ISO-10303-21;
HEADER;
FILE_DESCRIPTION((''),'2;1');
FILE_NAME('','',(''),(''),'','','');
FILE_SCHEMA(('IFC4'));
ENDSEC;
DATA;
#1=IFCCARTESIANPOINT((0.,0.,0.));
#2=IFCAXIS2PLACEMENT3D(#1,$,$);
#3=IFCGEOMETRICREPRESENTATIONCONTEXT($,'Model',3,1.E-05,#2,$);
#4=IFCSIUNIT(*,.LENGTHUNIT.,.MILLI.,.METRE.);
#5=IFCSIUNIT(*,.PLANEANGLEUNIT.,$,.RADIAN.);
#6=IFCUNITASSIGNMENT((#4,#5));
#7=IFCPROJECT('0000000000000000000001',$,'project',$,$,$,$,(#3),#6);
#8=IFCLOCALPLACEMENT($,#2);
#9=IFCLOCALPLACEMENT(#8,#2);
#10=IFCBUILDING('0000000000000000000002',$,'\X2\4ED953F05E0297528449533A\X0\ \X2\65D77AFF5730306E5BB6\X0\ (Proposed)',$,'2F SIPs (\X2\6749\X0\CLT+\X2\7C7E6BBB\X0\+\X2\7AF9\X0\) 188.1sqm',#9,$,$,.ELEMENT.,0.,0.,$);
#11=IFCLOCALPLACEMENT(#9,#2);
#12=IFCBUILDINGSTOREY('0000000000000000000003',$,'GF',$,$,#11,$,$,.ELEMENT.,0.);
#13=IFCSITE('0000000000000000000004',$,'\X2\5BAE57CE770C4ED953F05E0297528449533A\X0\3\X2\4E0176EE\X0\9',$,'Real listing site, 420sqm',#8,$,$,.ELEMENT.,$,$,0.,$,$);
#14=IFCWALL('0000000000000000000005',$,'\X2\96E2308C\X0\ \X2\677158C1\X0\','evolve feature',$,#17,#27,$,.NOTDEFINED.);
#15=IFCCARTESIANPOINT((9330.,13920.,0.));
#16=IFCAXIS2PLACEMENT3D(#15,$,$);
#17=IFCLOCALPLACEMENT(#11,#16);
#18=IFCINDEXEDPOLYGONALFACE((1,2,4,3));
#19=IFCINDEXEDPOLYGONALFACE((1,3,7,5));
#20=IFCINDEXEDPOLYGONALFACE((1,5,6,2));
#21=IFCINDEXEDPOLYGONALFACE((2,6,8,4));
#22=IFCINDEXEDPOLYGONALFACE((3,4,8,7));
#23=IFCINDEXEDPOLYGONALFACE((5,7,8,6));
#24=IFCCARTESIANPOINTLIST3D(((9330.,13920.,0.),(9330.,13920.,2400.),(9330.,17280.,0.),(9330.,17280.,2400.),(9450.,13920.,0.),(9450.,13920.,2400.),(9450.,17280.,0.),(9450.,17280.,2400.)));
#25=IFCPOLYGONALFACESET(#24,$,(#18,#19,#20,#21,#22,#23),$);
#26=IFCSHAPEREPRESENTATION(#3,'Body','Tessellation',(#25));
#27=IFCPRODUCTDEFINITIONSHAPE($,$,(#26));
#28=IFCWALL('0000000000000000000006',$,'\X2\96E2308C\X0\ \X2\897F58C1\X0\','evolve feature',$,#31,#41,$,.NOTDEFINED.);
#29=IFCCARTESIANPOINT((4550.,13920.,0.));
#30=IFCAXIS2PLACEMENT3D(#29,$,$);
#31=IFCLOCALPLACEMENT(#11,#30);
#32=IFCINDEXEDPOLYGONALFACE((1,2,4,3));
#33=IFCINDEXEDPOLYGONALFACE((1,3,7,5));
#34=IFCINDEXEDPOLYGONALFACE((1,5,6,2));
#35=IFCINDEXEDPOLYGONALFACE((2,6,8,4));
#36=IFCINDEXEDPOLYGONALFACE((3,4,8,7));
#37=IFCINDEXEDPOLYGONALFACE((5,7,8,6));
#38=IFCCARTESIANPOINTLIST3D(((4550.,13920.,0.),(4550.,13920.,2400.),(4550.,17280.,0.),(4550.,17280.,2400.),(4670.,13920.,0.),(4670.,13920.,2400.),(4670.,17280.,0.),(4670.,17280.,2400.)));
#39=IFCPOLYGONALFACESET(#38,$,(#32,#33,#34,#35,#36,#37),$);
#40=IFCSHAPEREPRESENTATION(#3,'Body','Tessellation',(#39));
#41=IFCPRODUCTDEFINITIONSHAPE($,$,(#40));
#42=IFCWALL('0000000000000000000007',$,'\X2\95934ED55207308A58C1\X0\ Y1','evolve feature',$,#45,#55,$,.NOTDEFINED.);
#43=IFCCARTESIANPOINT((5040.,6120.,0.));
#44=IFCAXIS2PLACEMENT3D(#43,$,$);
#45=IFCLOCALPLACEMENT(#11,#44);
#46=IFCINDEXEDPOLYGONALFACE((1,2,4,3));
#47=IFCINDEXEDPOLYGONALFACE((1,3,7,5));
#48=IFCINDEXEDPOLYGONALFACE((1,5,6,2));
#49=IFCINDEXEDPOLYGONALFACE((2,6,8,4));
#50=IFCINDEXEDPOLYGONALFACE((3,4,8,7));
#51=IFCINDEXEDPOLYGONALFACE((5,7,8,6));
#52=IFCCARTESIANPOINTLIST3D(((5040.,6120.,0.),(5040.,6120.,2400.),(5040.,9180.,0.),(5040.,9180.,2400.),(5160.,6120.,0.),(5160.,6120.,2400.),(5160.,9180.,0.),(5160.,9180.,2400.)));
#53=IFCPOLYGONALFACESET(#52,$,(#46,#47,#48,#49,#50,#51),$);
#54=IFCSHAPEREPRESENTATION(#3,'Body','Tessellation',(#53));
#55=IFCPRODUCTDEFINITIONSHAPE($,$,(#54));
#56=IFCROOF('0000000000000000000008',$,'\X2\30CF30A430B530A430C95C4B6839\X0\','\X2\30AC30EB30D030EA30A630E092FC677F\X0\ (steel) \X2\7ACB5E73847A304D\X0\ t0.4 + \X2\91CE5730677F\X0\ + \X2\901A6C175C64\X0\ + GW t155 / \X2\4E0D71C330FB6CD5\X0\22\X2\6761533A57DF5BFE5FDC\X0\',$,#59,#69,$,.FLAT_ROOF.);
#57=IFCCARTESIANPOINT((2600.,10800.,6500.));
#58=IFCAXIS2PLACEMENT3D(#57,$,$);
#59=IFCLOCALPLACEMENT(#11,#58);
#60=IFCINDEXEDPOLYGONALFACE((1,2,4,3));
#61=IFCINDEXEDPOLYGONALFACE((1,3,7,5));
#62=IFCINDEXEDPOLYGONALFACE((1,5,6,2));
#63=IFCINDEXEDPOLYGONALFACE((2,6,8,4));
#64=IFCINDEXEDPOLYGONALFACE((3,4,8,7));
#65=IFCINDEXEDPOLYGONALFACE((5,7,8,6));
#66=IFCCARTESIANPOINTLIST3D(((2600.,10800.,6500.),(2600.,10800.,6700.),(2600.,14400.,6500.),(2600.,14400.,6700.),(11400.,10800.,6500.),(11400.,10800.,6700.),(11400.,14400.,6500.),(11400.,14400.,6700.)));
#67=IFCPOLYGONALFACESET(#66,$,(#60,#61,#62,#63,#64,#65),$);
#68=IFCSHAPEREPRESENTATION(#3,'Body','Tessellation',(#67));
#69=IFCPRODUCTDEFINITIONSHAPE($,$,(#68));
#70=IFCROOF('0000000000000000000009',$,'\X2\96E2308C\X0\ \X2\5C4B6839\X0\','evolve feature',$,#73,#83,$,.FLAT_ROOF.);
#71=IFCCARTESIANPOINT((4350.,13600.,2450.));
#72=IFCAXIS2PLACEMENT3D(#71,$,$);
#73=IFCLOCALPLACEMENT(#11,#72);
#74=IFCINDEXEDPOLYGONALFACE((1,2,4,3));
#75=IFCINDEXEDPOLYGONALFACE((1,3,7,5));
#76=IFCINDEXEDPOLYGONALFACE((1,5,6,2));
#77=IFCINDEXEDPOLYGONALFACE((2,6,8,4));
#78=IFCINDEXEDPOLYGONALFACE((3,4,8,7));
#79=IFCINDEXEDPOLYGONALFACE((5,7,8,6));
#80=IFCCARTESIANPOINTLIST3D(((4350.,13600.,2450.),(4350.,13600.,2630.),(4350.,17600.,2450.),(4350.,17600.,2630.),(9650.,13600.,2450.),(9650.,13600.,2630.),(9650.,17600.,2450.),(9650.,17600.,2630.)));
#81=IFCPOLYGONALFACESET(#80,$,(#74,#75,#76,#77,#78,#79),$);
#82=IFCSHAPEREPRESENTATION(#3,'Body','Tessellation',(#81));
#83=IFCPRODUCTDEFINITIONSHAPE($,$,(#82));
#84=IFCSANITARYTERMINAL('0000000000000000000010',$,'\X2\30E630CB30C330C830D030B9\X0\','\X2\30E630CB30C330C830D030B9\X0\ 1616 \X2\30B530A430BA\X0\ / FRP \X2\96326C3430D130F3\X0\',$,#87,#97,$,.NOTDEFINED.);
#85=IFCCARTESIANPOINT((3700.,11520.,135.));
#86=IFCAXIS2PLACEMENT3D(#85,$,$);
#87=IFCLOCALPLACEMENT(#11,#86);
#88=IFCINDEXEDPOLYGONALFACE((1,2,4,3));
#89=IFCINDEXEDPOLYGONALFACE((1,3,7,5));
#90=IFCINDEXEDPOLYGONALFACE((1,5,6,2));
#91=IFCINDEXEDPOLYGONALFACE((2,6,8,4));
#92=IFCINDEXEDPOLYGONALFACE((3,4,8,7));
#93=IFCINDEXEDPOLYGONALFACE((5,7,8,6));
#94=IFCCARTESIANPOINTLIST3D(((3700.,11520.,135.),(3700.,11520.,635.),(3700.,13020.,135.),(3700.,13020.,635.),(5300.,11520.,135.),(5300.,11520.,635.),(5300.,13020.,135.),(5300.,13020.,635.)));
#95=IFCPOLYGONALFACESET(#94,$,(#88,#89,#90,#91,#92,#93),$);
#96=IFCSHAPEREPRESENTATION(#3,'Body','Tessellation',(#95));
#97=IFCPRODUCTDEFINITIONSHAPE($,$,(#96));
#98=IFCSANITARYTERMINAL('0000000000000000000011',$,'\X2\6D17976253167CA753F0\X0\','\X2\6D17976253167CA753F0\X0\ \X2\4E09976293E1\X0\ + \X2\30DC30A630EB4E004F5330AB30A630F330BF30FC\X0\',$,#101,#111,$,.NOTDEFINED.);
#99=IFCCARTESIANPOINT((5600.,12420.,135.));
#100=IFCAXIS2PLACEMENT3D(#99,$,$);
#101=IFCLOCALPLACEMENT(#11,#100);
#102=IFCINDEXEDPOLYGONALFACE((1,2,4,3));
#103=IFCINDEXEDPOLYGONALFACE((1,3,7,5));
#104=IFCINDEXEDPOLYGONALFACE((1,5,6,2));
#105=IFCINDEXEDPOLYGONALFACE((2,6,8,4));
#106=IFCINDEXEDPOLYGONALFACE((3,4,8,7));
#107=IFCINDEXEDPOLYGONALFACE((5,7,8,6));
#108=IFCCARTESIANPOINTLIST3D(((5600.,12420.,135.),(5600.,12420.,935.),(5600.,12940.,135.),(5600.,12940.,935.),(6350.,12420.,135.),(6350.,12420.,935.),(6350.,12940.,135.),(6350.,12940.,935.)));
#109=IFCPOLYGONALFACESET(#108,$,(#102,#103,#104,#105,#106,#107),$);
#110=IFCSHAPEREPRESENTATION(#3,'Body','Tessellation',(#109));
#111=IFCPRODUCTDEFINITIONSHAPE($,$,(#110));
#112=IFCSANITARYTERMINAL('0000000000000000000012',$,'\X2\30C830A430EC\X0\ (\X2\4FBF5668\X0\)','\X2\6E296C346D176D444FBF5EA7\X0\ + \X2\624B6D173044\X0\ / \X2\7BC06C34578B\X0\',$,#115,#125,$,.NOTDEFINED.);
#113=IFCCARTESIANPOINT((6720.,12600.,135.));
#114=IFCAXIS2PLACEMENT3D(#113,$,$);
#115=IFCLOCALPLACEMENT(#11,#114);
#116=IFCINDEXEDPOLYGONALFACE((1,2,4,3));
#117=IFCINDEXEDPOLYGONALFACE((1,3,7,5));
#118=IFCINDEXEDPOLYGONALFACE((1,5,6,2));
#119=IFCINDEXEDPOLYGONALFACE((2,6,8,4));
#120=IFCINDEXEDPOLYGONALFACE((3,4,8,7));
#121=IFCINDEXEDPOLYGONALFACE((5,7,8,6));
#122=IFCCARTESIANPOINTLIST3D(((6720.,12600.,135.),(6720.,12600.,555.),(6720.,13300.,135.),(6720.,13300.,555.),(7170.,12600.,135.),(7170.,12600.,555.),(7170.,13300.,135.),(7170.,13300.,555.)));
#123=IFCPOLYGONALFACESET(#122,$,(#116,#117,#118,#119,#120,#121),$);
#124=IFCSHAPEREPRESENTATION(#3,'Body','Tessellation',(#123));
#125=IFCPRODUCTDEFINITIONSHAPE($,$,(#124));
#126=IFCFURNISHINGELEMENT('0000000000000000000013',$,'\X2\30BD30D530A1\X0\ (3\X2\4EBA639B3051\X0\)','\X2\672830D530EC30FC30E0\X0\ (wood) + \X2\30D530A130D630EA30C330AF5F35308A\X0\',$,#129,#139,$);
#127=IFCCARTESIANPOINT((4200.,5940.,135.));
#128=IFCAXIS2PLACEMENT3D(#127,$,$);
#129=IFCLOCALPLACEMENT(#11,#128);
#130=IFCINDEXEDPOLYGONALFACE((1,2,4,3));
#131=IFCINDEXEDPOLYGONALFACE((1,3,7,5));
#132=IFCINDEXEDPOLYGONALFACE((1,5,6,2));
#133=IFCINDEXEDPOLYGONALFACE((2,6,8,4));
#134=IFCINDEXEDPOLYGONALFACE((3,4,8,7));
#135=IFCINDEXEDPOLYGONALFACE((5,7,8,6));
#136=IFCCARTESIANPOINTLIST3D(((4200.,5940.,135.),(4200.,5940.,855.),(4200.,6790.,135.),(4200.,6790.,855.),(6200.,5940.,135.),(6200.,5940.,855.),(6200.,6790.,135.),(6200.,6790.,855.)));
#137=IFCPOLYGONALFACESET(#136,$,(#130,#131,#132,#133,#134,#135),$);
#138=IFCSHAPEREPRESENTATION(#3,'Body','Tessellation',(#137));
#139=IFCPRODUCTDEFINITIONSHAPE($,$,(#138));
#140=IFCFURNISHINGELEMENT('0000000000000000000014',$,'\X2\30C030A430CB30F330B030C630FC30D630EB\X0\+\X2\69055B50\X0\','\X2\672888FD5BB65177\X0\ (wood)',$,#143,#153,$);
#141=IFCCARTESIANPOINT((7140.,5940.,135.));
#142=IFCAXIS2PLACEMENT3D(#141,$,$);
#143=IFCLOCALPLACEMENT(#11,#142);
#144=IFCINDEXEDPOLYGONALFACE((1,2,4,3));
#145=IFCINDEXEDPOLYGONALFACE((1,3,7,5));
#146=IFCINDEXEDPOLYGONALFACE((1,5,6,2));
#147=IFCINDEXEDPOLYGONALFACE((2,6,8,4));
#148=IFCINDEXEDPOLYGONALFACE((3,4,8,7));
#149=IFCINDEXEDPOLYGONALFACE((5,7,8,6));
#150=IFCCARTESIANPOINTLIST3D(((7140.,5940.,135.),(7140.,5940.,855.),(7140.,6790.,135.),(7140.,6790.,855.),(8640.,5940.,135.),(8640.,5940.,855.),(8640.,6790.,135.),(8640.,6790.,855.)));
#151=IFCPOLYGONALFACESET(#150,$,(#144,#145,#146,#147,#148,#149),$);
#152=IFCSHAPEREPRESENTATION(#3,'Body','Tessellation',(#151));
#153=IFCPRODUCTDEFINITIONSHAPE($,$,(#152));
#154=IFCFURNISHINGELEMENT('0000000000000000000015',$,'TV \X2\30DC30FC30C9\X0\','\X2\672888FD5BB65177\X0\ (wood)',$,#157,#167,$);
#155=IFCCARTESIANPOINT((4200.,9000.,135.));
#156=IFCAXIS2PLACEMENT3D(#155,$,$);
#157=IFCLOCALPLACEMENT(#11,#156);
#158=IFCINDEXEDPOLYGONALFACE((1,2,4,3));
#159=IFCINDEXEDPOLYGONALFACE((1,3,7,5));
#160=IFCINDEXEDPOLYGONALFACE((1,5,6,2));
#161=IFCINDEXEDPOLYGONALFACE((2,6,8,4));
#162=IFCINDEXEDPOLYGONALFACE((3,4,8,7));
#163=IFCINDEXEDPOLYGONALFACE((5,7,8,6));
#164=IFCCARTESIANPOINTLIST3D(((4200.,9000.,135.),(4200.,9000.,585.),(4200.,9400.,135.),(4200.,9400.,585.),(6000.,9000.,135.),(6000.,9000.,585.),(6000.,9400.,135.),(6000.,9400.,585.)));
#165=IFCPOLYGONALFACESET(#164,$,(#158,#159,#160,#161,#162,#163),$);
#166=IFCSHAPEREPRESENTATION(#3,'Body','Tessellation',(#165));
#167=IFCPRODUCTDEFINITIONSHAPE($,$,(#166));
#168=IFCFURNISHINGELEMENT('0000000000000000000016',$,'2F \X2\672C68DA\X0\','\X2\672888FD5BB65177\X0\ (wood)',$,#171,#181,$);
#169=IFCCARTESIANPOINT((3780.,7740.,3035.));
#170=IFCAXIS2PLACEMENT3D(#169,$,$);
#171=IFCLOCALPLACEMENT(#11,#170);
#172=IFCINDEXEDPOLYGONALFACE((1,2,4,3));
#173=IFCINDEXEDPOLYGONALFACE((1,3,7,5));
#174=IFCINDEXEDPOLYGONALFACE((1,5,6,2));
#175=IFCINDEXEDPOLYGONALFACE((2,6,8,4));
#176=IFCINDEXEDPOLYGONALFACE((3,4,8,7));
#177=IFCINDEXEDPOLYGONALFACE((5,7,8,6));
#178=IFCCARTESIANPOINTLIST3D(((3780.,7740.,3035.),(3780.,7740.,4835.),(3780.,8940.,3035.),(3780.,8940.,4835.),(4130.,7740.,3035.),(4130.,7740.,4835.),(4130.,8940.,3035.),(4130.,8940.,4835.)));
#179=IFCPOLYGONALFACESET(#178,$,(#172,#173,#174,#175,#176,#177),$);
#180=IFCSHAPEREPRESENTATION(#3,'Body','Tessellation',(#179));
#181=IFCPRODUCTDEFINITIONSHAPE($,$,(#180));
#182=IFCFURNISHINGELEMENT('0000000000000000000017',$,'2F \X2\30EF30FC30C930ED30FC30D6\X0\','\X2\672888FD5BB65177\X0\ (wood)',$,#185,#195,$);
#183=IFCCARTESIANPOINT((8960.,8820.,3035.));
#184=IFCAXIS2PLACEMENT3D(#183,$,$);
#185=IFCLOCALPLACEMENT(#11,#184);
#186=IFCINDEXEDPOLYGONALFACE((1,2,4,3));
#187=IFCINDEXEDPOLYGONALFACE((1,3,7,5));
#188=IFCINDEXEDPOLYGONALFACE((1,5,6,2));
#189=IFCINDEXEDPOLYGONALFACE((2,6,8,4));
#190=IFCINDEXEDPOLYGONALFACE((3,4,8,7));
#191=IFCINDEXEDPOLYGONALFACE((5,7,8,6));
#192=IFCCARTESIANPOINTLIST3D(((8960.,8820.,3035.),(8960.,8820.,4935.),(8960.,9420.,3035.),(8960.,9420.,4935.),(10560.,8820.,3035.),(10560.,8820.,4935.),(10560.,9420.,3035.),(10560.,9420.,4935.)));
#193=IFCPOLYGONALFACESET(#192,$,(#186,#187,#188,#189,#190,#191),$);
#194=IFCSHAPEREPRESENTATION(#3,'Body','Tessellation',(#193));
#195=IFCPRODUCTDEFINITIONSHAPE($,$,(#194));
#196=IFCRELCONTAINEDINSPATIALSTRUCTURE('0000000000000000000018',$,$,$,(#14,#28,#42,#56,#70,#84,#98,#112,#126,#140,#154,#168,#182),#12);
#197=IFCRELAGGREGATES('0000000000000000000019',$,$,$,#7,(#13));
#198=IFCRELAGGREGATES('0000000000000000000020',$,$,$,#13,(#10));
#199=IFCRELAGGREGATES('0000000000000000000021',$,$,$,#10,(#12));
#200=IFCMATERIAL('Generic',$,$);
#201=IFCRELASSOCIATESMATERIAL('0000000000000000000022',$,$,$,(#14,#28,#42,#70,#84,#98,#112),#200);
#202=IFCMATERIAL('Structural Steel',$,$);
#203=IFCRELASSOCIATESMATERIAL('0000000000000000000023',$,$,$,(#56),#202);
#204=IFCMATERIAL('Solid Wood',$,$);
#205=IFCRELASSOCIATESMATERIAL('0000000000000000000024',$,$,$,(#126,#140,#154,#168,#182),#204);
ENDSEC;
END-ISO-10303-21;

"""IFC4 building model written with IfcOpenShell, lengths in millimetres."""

from ifc_helpers import new_model, si_unit, frame, frame_2d, origin, place, context, project, spatial, rectangle, extrude, material, element, save


model = new_model("IFC4")

# Units and contexts
model_context = context("Model", 3, precision=1e-05, world=origin())
ifc_project = project(units=[si_unit("LENGTHUNIT", "METRE", prefix="MILLI"), si_unit("PLANEANGLEUNIT", "RADIAN")], contexts=[model_context])

# Site, building, storey
site_placement = place(None, origin())
site = spatial("IfcSite", under=ifc_project, at=site_placement, Name="宮城県仙台市青葉区3丁目9", ObjectType="Real listing site, 420sqm", CompositionType="ELEMENT", RefElevation=0.0)
building_placement = place(site_placement, origin())
building = spatial("IfcBuilding", under=site, at=building_placement, Name="仙台市青葉区 旗竿地の家 (Proposed)", ObjectType="2F SIPs (杉CLT+籾殻+竹) 188.1sqm", CompositionType="ELEMENT", ElevationOfRefHeight=0.0, ElevationOfTerrain=0.0)
storey_placement = place(building_placement, origin())
storey = spatial("IfcBuildingStorey", under=building, at=storey_placement, Name="GF", CompositionType="ELEMENT", Elevation=0.0)

# Shared definitions
ifc_material_1 = material(Name="Generic")

# Shared definitions
ifc_material_2 = material(Name="Solid Wood")

# Walls
wall_1_placement = place(storey_placement, frame((9330.0, 13920.0, 0.0)))
element("IfcWall", 1, at=wall_1_placement, inside=storey, material=ifc_material_1, Name="離れ 東壁", Description="evolve feature", PredefinedType="NOTDEFINED", context=model_context, shape_type="SweptSolid", body=[
    extrude(rectangle(XDim=120.0, YDim=3360.0, at=frame_2d((60.0, 1680.0))), frame((9330.0, 13920.0, 0.0)), (0.0, 0.0, 1.0), 2400.0),
])
wall_2_placement = place(storey_placement, frame((4550.0, 13920.0, 0.0)))
element("IfcWall", 2, at=wall_2_placement, inside=storey, material=ifc_material_1, Name="離れ 西壁", Description="evolve feature", PredefinedType="NOTDEFINED", context=model_context, shape_type="SweptSolid", body=[
    extrude(rectangle(XDim=120.0, YDim=3360.0, at=frame_2d((60.0, 1680.0))), frame((4550.0, 13920.0, 0.0)), (0.0, 0.0, 1.0), 2400.0),
])
wall_3_placement = place(storey_placement, frame((5040.0, 6120.0, 0.0)))
element("IfcWall", 3, at=wall_3_placement, inside=storey, material=ifc_material_1, Name="間仕切り壁 Y1", Description="evolve feature", PredefinedType="NOTDEFINED", context=model_context, shape_type="SweptSolid", body=[
    extrude(rectangle(XDim=120.0, YDim=3060.0, at=frame_2d((60.0, 1530.0))), frame((5040.0, 6120.0, 0.0)), (0.0, 0.0, 1.0), 2400.0),
])

# Roofs
ifc_material_3 = material(Name="Structural Steel")
roof_1_placement = place(storey_placement, frame((2600.0, 10800.0, 6500.0)))
element("IfcRoof", 4, at=roof_1_placement, inside=storey, material=ifc_material_3, Name="ハイサイド屋根", Description="ガルバリウム鋼板 (steel) 立平葺き t0.4 + 野地板 + 通気層 + GW t155 / 不燃・法22条区域対応", PredefinedType="FLAT_ROOF", context=model_context, shape_type="SweptSolid", body=[
    extrude(rectangle(XDim=8800.0, YDim=3600.0, at=frame_2d((4400.0, 1800.0))), frame((2600.0, 10800.0, 6500.0)), (0.0, 0.0, 1.0), 200.0),
])
roof_2_placement = place(storey_placement, frame((4350.0, 13600.0, 2450.0)))
element("IfcRoof", 5, at=roof_2_placement, inside=storey, material=ifc_material_1, Name="離れ 屋根", Description="evolve feature", PredefinedType="FLAT_ROOF", context=model_context, shape_type="SweptSolid", body=[
    extrude(rectangle(XDim=5300.0, YDim=4000.0, at=frame_2d((2650.0, 2000.0))), frame((4350.0, 13600.0, 2450.0)), (0.0, 0.0, 1.0), 180.0),
])

# Sanitary terminals
sanitary_terminal_1_placement = place(storey_placement, frame((3700.0, 11520.0, 135.0)))
element("IfcSanitaryTerminal", 6, at=sanitary_terminal_1_placement, inside=storey, material=ifc_material_1, Name="ユニットバス", Description="ユニットバス 1616 サイズ / FRP 防水パン", PredefinedType="NOTDEFINED", context=model_context, shape_type="SweptSolid", body=[
    extrude(rectangle(XDim=1600.0, YDim=1500.0, at=frame_2d((800.0, 750.0))), frame((3700.0, 11520.0, 135.0)), (0.0, 0.0, 1.0), 500.0),
])
sanitary_terminal_2_placement = place(storey_placement, frame((5600.0, 12420.0, 135.0)))
element("IfcSanitaryTerminal", 7, at=sanitary_terminal_2_placement, inside=storey, material=ifc_material_1, Name="洗面化粧台", Description="洗面化粧台 三面鏡 + ボウル一体カウンター", PredefinedType="NOTDEFINED", context=model_context, shape_type="SweptSolid", body=[
    extrude(rectangle(XDim=750.0, YDim=520.0, at=frame_2d((375.0, 260.0))), frame((5600.0, 12420.0, 135.0)), (0.0, 0.0, 1.0), 800.0),
])
sanitary_terminal_3_placement = place(storey_placement, frame((6720.0, 12600.0, 135.0)))
element("IfcSanitaryTerminal", 8, at=sanitary_terminal_3_placement, inside=storey, material=ifc_material_1, Name="トイレ (便器)", Description="温水洗浄便座 + 手洗い / 節水型", PredefinedType="NOTDEFINED", context=model_context, shape_type="SweptSolid", body=[
    extrude(rectangle(XDim=450.0, YDim=700.0, at=frame_2d((225.0, 350.0))), frame((6720.0, 12600.0, 135.0)), (0.0, 0.0, 1.0), 420.0),
])

# Furnishing elements
furnishing_1_placement = place(storey_placement, frame((4200.0, 5940.0, 135.0)))
element("IfcFurnishingElement", 9, at=furnishing_1_placement, inside=storey, material=ifc_material_2, Name="ソファ (3人掛け)", Description="木フレーム (wood) + ファブリック張り", context=model_context, shape_type="SweptSolid", body=[
    extrude(rectangle(XDim=2000.0, YDim=850.0, at=frame_2d((1000.0, 425.0))), frame((4200.0, 5940.0, 135.0)), (0.0, 0.0, 1.0), 720.0),
])
furnishing_2_placement = place(storey_placement, frame((7140.0, 5940.0, 135.0)))
element("IfcFurnishingElement", 10, at=furnishing_2_placement, inside=storey, material=ifc_material_2, Name="ダイニングテーブル+椅子", Description="木製家具 (wood)", context=model_context, shape_type="SweptSolid", body=[
    extrude(rectangle(XDim=1500.0, YDim=850.0, at=frame_2d((750.0, 425.0))), frame((7140.0, 5940.0, 135.0)), (0.0, 0.0, 1.0), 720.0),
])
furnishing_3_placement = place(storey_placement, frame((4200.0, 9000.0, 135.0)))
element("IfcFurnishingElement", 11, at=furnishing_3_placement, inside=storey, material=ifc_material_2, Name="TV ボード", Description="木製家具 (wood)", context=model_context, shape_type="SweptSolid", body=[
    extrude(rectangle(XDim=1800.0, YDim=400.0, at=frame_2d((900.0, 200.0))), frame((4200.0, 9000.0, 135.0)), (0.0, 0.0, 1.0), 450.0),
])
furnishing_4_placement = place(storey_placement, frame((3780.0, 7740.0, 3035.0)))
element("IfcFurnishingElement", 12, at=furnishing_4_placement, inside=storey, material=ifc_material_2, Name="2F 本棚", Description="木製家具 (wood)", context=model_context, shape_type="SweptSolid", body=[
    extrude(rectangle(XDim=350.0, YDim=1200.0, at=frame_2d((175.0, 600.0))), frame((3780.0, 7740.0, 3035.0)), (0.0, 0.0, 1.0), 1800.0),
])
furnishing_5_placement = place(storey_placement, frame((8960.0, 8820.0, 3035.0)))
element("IfcFurnishingElement", 13, at=furnishing_5_placement, inside=storey, material=ifc_material_2, Name="2F ワードローブ", Description="木製家具 (wood)", context=model_context, shape_type="SweptSolid", body=[
    extrude(rectangle(XDim=1600.0, YDim=600.0, at=frame_2d((800.0, 300.0))), frame((8960.0, 8820.0, 3035.0)), (0.0, 0.0, 1.0), 1900.0),
])

save(model, "model.ifc")
